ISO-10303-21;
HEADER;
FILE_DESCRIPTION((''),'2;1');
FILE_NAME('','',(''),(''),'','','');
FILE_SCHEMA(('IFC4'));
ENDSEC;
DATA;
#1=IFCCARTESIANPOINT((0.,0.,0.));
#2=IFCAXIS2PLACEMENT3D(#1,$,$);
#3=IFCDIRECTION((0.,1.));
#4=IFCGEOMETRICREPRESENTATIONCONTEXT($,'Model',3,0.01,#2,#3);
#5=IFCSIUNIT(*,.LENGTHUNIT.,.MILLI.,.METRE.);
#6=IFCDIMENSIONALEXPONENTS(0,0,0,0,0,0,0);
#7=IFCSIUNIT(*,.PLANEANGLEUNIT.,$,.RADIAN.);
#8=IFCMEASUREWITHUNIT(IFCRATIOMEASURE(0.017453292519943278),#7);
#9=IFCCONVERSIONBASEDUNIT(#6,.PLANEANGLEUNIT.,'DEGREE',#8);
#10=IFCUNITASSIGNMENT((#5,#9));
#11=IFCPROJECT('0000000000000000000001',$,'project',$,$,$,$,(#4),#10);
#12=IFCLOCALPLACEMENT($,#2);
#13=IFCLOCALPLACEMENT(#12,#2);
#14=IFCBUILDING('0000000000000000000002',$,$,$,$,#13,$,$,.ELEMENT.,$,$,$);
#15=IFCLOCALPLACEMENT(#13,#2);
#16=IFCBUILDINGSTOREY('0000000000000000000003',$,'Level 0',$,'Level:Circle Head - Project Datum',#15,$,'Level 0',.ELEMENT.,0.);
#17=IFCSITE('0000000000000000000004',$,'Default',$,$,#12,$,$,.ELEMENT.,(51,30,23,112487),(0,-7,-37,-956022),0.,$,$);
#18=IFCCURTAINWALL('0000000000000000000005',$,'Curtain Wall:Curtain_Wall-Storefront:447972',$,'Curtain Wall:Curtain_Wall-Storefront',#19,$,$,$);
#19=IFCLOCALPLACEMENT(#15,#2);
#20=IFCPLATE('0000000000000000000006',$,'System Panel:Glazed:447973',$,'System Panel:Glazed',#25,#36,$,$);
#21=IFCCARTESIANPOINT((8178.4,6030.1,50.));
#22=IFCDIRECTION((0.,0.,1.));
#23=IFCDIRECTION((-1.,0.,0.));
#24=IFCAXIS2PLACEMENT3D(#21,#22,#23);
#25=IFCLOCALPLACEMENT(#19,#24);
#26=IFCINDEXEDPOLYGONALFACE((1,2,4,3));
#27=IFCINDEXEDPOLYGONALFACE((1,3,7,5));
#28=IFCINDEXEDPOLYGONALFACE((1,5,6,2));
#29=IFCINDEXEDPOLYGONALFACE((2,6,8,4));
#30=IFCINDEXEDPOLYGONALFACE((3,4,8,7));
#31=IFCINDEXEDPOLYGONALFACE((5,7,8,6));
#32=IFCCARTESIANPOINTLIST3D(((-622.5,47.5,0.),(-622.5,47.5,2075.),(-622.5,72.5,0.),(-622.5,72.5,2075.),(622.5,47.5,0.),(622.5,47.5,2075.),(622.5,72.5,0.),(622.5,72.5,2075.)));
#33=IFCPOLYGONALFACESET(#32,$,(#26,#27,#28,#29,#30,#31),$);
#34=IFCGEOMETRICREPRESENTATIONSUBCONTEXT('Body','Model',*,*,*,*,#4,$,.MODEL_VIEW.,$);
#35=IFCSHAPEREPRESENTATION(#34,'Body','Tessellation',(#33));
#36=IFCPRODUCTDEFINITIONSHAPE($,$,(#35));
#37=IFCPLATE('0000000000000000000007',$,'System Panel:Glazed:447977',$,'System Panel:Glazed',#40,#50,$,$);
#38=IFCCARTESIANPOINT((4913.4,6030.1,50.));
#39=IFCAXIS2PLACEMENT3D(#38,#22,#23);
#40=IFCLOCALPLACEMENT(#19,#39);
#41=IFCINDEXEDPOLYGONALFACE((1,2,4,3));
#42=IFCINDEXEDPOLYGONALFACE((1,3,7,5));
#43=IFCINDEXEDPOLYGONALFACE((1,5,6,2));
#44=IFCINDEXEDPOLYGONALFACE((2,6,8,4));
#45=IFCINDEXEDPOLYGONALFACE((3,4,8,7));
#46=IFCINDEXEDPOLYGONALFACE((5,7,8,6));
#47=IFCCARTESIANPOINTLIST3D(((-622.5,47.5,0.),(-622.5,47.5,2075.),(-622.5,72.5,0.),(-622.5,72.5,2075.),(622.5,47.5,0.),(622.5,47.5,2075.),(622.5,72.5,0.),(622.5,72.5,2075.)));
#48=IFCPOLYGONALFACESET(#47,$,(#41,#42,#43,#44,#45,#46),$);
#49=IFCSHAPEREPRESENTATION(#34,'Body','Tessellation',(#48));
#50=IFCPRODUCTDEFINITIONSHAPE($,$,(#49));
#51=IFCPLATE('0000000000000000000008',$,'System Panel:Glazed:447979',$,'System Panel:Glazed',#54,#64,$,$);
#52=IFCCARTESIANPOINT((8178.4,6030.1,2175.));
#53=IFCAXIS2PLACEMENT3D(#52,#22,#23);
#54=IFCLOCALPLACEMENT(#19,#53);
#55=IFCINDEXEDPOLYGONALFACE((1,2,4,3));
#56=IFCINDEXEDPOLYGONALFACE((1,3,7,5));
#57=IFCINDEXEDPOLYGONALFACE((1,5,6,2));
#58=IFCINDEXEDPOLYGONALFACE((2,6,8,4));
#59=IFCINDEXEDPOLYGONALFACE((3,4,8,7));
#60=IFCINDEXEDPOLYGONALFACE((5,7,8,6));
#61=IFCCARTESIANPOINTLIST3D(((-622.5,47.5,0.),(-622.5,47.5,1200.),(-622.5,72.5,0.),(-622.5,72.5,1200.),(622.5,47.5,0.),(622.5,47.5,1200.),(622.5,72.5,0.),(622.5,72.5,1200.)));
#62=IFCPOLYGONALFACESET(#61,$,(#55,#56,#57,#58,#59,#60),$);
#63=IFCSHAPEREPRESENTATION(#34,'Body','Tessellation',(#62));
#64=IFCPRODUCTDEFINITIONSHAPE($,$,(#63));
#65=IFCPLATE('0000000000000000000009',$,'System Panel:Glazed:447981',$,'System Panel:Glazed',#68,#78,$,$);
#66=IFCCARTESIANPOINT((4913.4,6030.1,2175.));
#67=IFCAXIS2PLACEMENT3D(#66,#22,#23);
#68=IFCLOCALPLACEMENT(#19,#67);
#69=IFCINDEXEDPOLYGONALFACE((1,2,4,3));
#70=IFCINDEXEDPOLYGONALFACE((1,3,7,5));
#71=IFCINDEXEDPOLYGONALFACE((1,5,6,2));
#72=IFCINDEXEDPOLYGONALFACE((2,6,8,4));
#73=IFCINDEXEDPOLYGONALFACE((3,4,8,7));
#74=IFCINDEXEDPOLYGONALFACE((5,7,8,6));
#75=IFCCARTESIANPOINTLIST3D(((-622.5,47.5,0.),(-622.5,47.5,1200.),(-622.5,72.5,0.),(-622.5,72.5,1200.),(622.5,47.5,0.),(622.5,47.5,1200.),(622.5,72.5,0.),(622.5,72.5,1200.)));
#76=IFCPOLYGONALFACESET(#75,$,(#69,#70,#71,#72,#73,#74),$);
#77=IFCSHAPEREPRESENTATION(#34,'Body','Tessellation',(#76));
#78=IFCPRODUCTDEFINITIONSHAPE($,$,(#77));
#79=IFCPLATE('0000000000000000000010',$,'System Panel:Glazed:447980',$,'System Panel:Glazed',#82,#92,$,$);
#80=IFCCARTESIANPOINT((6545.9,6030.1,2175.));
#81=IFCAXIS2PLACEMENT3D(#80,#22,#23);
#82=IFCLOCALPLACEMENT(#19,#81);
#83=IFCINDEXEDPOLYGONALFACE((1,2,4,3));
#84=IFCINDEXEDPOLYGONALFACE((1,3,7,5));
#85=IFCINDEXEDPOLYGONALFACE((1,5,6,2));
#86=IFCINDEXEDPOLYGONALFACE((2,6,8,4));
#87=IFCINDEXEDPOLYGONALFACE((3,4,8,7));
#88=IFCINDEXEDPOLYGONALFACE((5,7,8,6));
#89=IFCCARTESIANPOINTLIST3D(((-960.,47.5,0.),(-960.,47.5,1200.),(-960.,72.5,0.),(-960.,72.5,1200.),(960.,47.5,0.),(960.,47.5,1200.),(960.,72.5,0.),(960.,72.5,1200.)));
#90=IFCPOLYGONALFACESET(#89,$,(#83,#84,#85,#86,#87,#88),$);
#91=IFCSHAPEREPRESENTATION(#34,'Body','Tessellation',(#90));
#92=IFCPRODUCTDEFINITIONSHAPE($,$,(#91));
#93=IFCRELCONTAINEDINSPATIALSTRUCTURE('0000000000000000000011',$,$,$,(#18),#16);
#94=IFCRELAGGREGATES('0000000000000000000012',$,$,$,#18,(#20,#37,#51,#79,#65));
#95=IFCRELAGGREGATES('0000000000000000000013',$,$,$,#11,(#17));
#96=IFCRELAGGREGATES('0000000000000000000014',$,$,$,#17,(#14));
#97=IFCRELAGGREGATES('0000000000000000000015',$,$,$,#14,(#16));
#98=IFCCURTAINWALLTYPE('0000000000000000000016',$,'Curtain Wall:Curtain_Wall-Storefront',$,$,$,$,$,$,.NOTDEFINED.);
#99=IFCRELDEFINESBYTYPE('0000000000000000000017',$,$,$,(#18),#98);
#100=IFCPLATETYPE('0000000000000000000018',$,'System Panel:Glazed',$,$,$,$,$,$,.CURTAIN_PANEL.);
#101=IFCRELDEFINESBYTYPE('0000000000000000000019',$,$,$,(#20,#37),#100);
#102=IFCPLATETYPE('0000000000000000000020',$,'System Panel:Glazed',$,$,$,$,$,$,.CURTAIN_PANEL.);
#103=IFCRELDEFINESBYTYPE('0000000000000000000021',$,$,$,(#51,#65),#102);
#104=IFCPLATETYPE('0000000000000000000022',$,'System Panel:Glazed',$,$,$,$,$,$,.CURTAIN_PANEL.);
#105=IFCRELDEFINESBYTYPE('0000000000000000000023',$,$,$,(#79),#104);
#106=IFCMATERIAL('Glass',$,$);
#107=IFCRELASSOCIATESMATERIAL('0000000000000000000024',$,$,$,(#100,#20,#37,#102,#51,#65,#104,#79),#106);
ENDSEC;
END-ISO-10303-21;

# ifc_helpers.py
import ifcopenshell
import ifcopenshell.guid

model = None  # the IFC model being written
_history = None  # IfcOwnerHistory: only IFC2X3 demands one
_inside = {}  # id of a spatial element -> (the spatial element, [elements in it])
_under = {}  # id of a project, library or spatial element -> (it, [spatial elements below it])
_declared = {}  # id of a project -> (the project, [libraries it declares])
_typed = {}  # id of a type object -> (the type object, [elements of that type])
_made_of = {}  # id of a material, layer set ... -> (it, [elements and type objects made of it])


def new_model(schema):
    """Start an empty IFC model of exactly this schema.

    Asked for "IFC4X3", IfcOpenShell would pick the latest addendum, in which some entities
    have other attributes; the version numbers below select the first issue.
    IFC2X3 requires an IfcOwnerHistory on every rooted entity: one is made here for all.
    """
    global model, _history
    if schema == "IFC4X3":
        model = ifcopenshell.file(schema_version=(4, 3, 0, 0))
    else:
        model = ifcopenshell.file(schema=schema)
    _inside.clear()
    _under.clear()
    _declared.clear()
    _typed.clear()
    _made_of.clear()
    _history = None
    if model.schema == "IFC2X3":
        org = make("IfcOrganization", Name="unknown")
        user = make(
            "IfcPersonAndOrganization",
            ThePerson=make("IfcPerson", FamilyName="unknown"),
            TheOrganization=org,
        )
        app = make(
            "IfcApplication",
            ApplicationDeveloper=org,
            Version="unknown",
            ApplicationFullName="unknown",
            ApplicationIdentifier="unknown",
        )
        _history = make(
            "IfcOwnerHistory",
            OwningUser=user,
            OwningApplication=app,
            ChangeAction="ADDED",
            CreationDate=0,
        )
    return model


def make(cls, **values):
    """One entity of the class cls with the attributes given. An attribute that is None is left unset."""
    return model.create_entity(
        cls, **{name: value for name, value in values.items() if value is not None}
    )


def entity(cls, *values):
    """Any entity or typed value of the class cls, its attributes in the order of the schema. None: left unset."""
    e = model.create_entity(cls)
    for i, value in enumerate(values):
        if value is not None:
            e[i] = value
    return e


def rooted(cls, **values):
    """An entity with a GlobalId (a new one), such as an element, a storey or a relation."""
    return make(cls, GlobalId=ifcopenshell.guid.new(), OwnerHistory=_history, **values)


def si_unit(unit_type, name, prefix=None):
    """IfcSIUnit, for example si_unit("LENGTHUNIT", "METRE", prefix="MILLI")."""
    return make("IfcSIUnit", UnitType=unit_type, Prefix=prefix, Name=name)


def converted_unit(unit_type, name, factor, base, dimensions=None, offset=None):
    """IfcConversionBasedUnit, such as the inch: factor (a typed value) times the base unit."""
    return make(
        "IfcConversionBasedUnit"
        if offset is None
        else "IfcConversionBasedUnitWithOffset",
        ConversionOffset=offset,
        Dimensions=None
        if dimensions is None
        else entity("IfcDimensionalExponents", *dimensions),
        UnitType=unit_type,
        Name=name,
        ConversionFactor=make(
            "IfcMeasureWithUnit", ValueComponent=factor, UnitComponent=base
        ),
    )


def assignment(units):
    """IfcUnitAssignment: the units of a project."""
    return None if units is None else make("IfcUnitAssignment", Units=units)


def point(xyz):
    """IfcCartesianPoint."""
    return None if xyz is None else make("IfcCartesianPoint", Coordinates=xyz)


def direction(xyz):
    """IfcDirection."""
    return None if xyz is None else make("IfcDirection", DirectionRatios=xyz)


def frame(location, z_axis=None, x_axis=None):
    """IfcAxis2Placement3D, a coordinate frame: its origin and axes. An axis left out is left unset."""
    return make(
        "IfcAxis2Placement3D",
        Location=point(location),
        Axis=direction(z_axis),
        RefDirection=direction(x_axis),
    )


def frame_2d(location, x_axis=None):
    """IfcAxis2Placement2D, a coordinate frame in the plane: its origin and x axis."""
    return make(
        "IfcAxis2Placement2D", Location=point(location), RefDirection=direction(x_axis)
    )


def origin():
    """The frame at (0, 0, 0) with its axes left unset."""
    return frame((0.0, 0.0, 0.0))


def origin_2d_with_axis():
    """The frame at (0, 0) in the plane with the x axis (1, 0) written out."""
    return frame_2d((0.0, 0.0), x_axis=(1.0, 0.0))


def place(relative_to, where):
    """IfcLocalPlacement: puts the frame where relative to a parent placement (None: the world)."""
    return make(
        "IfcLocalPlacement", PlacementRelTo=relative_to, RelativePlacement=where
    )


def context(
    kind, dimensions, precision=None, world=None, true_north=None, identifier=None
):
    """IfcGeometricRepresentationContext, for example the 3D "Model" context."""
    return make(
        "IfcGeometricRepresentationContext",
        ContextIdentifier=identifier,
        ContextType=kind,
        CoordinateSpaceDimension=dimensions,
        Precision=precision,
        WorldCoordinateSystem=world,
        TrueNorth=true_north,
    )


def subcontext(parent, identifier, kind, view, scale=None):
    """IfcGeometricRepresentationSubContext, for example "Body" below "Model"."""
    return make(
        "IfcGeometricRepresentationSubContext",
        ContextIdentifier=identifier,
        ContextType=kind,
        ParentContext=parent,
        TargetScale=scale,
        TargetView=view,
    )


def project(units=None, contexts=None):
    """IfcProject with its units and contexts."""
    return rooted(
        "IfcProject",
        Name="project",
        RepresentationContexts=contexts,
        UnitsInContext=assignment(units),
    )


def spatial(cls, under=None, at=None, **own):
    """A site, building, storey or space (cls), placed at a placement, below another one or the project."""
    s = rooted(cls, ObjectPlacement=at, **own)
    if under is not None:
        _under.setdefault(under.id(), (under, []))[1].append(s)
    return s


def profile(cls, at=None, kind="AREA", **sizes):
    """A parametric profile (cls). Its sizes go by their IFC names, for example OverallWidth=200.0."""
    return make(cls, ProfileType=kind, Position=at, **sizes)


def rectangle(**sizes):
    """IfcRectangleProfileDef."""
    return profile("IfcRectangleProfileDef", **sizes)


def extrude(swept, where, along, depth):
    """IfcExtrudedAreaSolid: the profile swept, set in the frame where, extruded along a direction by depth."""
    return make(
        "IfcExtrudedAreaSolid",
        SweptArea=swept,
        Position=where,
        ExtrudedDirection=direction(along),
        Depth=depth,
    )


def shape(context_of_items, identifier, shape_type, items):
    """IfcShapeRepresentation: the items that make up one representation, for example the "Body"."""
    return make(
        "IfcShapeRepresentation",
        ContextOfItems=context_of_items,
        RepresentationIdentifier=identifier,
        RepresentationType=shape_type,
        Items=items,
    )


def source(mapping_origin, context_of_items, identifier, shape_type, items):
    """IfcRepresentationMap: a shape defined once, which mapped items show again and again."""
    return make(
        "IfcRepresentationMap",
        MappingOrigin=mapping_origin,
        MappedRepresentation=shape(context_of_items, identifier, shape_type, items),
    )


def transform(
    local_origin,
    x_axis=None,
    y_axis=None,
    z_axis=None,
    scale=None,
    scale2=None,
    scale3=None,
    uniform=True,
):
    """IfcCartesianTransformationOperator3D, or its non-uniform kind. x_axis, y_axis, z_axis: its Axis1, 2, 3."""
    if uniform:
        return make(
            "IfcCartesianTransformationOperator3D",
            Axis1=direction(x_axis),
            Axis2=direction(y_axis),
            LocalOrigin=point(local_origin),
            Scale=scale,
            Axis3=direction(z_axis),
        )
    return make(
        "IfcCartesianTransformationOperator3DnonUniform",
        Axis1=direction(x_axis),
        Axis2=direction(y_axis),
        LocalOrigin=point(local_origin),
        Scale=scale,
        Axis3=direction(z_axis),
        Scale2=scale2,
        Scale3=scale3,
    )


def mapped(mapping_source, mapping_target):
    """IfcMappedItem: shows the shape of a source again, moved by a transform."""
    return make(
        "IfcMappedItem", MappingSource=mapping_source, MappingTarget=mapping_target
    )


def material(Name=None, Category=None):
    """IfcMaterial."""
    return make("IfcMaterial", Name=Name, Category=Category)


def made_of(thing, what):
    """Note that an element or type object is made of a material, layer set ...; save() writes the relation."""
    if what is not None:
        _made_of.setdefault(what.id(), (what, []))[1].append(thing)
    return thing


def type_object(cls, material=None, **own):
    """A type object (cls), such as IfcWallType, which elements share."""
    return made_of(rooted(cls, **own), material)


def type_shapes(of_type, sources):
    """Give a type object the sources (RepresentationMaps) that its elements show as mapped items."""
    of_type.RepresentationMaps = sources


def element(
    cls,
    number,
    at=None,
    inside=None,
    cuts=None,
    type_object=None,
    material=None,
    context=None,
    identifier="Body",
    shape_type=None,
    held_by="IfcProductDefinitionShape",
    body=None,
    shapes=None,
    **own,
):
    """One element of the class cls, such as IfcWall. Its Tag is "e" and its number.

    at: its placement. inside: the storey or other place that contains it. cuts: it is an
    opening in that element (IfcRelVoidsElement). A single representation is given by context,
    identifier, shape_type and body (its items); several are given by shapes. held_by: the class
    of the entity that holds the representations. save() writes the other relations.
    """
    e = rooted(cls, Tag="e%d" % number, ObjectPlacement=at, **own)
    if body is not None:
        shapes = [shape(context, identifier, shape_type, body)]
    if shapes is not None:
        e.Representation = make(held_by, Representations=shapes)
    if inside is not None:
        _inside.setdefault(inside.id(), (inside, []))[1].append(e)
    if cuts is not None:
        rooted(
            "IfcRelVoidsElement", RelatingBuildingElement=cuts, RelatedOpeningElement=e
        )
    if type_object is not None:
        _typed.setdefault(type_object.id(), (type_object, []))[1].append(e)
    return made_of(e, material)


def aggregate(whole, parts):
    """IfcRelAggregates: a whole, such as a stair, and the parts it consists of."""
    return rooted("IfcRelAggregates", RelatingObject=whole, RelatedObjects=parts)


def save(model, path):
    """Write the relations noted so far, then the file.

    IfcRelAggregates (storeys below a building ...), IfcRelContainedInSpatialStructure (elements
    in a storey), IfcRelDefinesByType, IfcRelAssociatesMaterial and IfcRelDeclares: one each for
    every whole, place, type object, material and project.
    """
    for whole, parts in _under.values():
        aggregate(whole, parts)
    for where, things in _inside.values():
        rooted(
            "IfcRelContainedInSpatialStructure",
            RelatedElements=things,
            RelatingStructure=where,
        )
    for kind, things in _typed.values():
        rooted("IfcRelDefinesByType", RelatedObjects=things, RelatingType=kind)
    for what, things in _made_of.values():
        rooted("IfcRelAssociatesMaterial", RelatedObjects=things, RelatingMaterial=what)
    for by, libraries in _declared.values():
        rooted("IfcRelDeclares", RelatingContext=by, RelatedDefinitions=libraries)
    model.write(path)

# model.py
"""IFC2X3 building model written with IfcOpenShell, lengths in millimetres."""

from ifc_helpers import new_model, entity, si_unit, converted_unit, direction, frame, origin, origin_2d_with_axis, place, context, subcontext, project, spatial, rectangle, extrude, source, transform, mapped, material, type_object, type_shapes, element, aggregate, save


model = new_model("IFC2X3")

# Units and contexts
model_context = context("Model", 3, precision=0.01, world=origin(), true_north=direction((0.0, 1.0)))
body_context = subcontext(model_context, "Body", "Model", "MODEL_VIEW")
ifc_project = project(units=[si_unit("LENGTHUNIT", "METRE", prefix="MILLI"), converted_unit("PLANEANGLEUNIT", "DEGREE", entity("IfcRatioMeasure", 0.017453292519943278), si_unit("PLANEANGLEUNIT", "RADIAN"), dimensions=[0, 0, 0, 0, 0, 0, 0])], contexts=[model_context])

# Site, building, storey
site_placement = place(None, origin())
site = spatial("IfcSite", under=ifc_project, at=site_placement, Name="Default", CompositionType="ELEMENT", RefLatitude=(51, 30, 23, 112487), RefLongitude=(0, -7, -37, -956022), RefElevation=0.0)
building_placement = place(site_placement, origin())
building = spatial("IfcBuilding", under=site, at=building_placement, CompositionType="ELEMENT")
storey_placement = place(building_placement, origin())
storey = spatial("IfcBuildingStorey", under=building, at=storey_placement, Name="Level 0", ObjectType="Level:Circle Head - Project Datum", LongName="Level 0", CompositionType="ELEMENT", Elevation=0.0)

# Curtain wall, plates
curtain_wall_type = type_object("IfcCurtainWallType", Name="Curtain Wall:Curtain_Wall-Storefront", PredefinedType="NOTDEFINED")
curtain_wall_placement = place(storey_placement, origin())
curtain_wall = element("IfcCurtainWall", 1, at=curtain_wall_placement, inside=storey, type_object=curtain_wall_type, Name="Curtain Wall:Curtain_Wall-Storefront:447972", ObjectType="Curtain Wall:Curtain_Wall-Storefront")
ifc_material_1 = material(Name="Glass")
plate_type_1 = type_object("IfcPlateType", Name="System Panel:Glazed", PredefinedType="CURTAIN_PANEL", material=ifc_material_1)
shared_shape_1 = source(origin(), body_context, "Body", "SweptSolid", [
    extrude(rectangle(XDim=25.0, YDim=1245.0, at=origin_2d_with_axis()), frame((0.0, 60.0, 0.0), z_axis=(0.0, 0.0, 1.0), x_axis=(0.0, 1.0, 0.0)), (0.0, 0.0, 1.0), 2075.0),
])
type_shapes(plate_type_1, [shared_shape_1])
plate_1_placement = place(curtain_wall_placement, frame((8178.4, 6030.1, 50.0), z_axis=(0.0, 0.0, 1.0), x_axis=(-1.0, 0.0, 0.0)))
plate_1 = element("IfcPlate", 2, at=plate_1_placement, type_object=plate_type_1, material=ifc_material_1, Name="System Panel:Glazed:447973", ObjectType="System Panel:Glazed", context=body_context, shape_type="MappedRepresentation", body=[
    mapped(shared_shape_1, transform((0.0, 0.0, 0.0), scale=1.0)),
])
plate_2_placement = place(curtain_wall_placement, frame((4913.4, 6030.1, 50.0), z_axis=(0.0, 0.0, 1.0), x_axis=(-1.0, 0.0, 0.0)))
plate_2 = element("IfcPlate", 3, at=plate_2_placement, type_object=plate_type_1, material=ifc_material_1, Name="System Panel:Glazed:447977", ObjectType="System Panel:Glazed", context=body_context, shape_type="MappedRepresentation", body=[
    mapped(shared_shape_1, transform((0.0, 0.0, 0.0), scale=1.0)),
])
plate_type_2 = type_object("IfcPlateType", Name="System Panel:Glazed", PredefinedType="CURTAIN_PANEL", material=ifc_material_1)
shared_shape_2 = source(origin(), body_context, "Body", "SweptSolid", [
    extrude(rectangle(XDim=25.0, YDim=1245.0, at=origin_2d_with_axis()), frame((0.0, 60.0, 0.0), z_axis=(0.0, 0.0, 1.0), x_axis=(0.0, 1.0, 0.0)), (0.0, 0.0, 1.0), 1200.0),
])
type_shapes(plate_type_2, [shared_shape_2])
plate_3_placement = place(curtain_wall_placement, frame((8178.4, 6030.1, 2175.0), z_axis=(0.0, 0.0, 1.0), x_axis=(-1.0, 0.0, 0.0)))
plate_3 = element("IfcPlate", 4, at=plate_3_placement, type_object=plate_type_2, material=ifc_material_1, Name="System Panel:Glazed:447979", ObjectType="System Panel:Glazed", context=body_context, shape_type="MappedRepresentation", body=[
    mapped(shared_shape_2, transform((0.0, 0.0, 0.0), scale=1.0)),
])
plate_4_placement = place(curtain_wall_placement, frame((4913.4, 6030.1, 2175.0), z_axis=(0.0, 0.0, 1.0), x_axis=(-1.0, 0.0, 0.0)))
plate_4 = element("IfcPlate", 5, at=plate_4_placement, type_object=plate_type_2, material=ifc_material_1, Name="System Panel:Glazed:447981", ObjectType="System Panel:Glazed", context=body_context, shape_type="MappedRepresentation", body=[
    mapped(shared_shape_2, transform((0.0, 0.0, 0.0), scale=1.0)),
])
plate_type_3 = type_object("IfcPlateType", Name="System Panel:Glazed", PredefinedType="CURTAIN_PANEL", material=ifc_material_1)
shared_shape_3 = source(origin(), body_context, "Body", "SweptSolid", [
    extrude(rectangle(XDim=25.0, YDim=1920.0, at=origin_2d_with_axis()), frame((0.0, 60.0, 0.0), z_axis=(0.0, 0.0, 1.0), x_axis=(0.0, 1.0, 0.0)), (0.0, 0.0, 1.0), 1200.0),
])
type_shapes(plate_type_3, [shared_shape_3])
plate_5_placement = place(curtain_wall_placement, frame((6545.9, 6030.1, 2175.0), z_axis=(0.0, 0.0, 1.0), x_axis=(-1.0, 0.0, 0.0)))
plate_5 = element("IfcPlate", 6, at=plate_5_placement, type_object=plate_type_3, material=ifc_material_1, Name="System Panel:Glazed:447980", ObjectType="System Panel:Glazed", context=body_context, shape_type="MappedRepresentation", body=[
    mapped(shared_shape_3, transform((0.0, 0.0, 0.0), scale=1.0)),
])
aggregate(curtain_wall, [plate_1, plate_2, plate_3, plate_5, plate_4])

save(model, "model.ifc")
